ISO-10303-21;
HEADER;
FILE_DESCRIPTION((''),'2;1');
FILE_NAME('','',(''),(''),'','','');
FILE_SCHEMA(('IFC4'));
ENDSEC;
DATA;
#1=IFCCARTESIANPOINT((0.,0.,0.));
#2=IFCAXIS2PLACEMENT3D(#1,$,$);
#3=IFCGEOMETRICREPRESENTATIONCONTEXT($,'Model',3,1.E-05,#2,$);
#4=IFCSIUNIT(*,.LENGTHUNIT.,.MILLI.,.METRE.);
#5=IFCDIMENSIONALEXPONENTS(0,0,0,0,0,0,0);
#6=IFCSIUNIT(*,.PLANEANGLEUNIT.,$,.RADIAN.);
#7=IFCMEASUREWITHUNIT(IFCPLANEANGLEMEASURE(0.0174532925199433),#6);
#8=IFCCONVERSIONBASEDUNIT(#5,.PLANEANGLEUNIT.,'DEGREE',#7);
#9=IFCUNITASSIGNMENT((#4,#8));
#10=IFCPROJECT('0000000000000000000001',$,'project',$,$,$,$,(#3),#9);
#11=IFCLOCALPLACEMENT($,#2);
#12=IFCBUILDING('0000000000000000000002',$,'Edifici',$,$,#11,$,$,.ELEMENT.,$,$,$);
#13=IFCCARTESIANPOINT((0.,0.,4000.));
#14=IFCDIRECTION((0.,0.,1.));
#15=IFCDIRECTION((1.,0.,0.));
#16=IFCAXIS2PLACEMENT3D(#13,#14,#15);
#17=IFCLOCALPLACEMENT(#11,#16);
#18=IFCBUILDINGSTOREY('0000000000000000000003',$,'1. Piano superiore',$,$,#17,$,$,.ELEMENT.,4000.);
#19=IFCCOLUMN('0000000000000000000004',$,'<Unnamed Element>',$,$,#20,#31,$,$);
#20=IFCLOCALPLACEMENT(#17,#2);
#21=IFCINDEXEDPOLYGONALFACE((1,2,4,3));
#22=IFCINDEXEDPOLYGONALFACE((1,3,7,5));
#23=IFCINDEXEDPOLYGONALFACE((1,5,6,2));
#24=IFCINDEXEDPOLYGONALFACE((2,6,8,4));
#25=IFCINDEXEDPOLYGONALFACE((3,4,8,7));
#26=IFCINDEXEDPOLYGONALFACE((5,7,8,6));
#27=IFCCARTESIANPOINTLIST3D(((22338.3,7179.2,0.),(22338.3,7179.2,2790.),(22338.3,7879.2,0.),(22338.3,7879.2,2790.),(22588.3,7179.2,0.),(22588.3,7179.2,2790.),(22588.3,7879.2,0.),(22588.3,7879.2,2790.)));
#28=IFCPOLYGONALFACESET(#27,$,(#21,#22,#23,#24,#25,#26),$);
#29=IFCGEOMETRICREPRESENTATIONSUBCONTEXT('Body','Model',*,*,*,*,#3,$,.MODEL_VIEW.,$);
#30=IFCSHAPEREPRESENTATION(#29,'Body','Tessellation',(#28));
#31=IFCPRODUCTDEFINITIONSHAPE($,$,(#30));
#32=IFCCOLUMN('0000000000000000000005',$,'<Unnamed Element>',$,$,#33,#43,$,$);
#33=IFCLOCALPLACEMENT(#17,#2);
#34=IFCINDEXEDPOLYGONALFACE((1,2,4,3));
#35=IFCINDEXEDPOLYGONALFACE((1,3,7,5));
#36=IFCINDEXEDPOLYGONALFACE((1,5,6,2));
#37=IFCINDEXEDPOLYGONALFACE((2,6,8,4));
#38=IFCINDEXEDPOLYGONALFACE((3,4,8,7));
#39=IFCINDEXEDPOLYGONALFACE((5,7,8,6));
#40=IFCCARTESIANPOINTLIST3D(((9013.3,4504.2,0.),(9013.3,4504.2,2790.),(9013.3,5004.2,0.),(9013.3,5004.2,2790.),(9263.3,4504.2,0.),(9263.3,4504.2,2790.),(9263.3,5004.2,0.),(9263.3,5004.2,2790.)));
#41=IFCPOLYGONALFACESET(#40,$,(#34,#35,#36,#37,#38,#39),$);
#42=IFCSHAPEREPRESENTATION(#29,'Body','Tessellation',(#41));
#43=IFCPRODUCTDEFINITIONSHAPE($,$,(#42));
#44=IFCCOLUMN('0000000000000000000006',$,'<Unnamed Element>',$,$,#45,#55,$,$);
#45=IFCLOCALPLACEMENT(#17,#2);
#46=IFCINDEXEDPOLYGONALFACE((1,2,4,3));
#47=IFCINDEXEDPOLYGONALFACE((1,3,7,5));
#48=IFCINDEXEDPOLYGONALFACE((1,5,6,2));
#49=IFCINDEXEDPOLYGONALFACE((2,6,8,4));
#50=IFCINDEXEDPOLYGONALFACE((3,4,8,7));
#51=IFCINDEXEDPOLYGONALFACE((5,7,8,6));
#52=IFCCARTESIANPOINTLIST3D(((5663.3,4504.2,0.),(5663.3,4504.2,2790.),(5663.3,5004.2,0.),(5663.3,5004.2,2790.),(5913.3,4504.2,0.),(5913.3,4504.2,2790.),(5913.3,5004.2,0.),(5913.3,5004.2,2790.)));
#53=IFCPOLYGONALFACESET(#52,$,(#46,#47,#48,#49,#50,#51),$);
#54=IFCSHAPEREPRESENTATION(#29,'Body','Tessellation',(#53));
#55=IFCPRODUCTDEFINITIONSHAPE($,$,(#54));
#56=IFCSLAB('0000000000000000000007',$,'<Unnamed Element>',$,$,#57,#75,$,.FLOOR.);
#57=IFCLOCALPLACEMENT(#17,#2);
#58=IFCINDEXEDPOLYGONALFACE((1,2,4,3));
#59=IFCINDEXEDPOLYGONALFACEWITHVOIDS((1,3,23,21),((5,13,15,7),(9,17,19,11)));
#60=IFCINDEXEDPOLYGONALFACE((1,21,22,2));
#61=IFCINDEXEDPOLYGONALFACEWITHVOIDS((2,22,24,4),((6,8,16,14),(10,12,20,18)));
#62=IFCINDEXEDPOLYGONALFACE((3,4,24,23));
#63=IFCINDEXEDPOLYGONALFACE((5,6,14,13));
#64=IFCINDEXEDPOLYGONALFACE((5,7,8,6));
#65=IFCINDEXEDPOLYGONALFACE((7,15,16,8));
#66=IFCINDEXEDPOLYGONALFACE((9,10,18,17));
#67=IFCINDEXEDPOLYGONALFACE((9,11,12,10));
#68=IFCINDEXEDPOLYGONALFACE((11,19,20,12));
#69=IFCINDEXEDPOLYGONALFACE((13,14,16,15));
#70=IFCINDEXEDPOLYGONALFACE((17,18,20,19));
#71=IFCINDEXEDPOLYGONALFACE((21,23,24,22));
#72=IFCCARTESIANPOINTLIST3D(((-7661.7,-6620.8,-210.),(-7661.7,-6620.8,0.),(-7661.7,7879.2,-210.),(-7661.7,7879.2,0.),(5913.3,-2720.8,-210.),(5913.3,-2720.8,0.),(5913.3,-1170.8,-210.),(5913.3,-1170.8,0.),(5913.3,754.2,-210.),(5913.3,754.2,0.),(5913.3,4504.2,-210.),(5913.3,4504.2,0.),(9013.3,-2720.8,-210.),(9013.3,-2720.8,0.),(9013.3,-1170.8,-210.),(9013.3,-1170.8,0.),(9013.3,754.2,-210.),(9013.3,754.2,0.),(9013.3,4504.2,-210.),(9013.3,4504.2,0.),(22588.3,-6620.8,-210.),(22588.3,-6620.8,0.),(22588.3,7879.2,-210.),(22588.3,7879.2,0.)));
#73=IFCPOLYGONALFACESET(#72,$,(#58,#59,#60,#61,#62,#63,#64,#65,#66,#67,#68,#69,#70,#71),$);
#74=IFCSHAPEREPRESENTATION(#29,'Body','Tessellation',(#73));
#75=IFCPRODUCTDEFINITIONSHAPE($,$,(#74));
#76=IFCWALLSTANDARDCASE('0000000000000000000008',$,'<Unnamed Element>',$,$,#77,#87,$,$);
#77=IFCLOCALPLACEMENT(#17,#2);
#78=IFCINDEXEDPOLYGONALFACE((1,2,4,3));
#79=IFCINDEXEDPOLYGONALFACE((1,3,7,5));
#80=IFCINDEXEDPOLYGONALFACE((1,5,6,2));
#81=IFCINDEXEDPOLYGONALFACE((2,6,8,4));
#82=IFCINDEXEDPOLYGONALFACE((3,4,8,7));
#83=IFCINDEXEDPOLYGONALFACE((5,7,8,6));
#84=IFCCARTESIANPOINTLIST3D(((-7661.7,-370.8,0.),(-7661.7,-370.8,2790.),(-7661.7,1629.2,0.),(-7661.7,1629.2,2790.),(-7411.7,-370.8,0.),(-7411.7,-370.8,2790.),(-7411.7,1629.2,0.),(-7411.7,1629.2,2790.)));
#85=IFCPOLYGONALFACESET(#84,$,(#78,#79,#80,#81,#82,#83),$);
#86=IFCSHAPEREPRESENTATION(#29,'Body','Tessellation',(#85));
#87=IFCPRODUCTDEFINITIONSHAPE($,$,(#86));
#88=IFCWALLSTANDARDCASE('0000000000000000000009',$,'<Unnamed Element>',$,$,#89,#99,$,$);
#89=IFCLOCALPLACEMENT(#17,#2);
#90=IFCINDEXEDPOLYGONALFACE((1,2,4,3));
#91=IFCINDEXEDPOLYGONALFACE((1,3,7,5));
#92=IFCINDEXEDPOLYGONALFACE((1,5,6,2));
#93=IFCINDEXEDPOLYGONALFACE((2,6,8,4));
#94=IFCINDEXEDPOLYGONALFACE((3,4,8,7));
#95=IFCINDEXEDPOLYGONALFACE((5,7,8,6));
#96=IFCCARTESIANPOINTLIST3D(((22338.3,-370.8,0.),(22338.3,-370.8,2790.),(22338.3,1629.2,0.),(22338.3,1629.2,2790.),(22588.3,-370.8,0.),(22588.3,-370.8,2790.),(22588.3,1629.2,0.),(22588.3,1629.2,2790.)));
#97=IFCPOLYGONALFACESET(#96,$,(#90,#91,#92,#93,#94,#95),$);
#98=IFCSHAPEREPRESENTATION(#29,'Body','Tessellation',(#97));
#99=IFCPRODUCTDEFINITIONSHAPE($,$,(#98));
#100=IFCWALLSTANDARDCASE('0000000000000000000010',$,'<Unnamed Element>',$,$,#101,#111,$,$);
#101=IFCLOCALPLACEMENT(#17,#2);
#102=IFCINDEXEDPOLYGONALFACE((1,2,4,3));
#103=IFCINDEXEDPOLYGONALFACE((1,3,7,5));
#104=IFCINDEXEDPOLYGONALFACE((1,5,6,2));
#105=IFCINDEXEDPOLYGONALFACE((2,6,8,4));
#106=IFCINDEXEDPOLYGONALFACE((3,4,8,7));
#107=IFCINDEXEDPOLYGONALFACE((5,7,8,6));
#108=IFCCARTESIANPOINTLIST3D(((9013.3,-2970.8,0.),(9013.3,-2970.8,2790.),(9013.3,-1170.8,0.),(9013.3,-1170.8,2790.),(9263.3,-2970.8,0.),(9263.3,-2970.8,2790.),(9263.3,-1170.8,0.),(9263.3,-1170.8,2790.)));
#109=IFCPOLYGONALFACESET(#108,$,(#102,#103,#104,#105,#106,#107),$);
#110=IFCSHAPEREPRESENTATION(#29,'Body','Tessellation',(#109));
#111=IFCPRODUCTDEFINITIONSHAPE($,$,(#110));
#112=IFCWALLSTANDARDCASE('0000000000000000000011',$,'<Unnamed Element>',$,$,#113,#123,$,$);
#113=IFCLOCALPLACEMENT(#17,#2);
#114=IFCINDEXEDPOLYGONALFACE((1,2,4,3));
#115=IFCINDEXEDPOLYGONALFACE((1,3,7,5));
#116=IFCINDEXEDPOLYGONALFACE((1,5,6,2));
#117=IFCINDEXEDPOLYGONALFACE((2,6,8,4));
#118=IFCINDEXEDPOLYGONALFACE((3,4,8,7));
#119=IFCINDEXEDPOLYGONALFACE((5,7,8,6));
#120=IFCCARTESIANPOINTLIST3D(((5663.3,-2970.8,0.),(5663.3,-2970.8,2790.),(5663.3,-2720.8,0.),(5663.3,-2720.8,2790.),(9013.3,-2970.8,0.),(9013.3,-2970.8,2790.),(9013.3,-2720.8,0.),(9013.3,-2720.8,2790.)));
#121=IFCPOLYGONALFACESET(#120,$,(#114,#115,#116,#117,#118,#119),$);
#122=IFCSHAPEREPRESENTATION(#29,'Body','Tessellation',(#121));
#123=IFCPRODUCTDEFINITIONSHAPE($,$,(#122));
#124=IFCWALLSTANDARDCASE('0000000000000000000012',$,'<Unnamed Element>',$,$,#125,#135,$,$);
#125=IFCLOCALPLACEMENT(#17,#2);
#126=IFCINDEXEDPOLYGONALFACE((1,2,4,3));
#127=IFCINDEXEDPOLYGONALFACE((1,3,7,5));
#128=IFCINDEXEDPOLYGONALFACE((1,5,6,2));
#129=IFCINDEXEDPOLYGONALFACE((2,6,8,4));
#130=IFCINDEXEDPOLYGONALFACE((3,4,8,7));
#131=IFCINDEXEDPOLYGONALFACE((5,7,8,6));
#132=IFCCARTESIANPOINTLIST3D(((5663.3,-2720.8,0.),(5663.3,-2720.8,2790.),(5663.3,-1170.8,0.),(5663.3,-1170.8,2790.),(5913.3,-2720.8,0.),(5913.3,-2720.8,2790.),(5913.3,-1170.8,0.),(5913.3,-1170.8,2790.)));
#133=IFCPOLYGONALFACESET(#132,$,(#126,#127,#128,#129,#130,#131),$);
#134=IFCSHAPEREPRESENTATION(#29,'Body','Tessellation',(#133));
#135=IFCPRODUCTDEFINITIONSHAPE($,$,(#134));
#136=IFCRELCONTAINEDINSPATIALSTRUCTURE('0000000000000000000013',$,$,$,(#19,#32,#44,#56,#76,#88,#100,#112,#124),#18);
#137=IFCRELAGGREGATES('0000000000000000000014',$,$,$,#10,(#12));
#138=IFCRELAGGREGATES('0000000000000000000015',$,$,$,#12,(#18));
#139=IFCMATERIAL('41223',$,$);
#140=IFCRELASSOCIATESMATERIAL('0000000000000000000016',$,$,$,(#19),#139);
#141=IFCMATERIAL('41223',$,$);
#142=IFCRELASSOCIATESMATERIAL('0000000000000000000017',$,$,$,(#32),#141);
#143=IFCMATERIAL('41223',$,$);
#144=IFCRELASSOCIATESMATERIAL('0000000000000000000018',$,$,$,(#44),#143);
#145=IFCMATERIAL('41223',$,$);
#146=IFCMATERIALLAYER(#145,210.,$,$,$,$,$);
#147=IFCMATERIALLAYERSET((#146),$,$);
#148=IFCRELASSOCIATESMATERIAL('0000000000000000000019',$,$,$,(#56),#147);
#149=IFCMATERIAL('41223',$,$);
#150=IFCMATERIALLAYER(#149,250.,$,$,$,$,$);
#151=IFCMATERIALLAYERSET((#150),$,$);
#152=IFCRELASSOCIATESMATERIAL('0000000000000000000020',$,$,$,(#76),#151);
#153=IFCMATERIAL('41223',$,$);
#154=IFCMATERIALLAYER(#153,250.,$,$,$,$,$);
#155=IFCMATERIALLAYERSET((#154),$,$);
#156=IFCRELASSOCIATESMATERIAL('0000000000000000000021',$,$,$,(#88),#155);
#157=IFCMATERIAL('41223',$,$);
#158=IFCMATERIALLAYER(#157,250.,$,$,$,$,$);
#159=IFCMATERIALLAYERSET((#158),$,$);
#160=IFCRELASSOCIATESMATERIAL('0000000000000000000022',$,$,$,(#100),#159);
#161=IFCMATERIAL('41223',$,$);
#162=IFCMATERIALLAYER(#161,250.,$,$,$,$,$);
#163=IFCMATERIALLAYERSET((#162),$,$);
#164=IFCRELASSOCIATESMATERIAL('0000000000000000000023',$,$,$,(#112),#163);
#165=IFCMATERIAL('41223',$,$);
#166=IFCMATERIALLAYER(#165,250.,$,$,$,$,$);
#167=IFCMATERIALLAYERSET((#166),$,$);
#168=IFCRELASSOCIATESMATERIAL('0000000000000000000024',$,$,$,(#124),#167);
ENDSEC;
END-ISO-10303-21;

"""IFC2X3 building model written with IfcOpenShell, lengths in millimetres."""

from ifc_helpers import new_model, entity, si_unit, converted_unit, frame, frame_2d, origin, origin_with_axes, place, context, subcontext, project, spatial, polyline, rectangle, outline, extrude, material, layer, layer_set, layer_usage, element, save


model = new_model("IFC2X3")

# Units and contexts
model_context = context("Model", 3, precision=1e-05, world=origin())
body_context = subcontext(model_context, "Body", "Model", "MODEL_VIEW")
ifc_project = project(units=[si_unit("LENGTHUNIT", "METRE", prefix="MILLI"), converted_unit("PLANEANGLEUNIT", "DEGREE", entity("IfcPlaneAngleMeasure", 0.0174532925199433), si_unit("PLANEANGLEUNIT", "RADIAN"), dimensions=[0, 0, 0, 0, 0, 0, 0])], contexts=[model_context])

# Building, storey
building_placement = place(None, origin())
building = spatial("IfcBuilding", under=ifc_project, at=building_placement, Name="Edifici", CompositionType="ELEMENT")
storey_placement = place(building_placement, frame((0.0, 0.0, 4000.0), z_axis=(0.0, 0.0, 1.0), x_axis=(1.0, 0.0, 0.0)))
storey = spatial("IfcBuildingStorey", under=building, at=storey_placement, Name="1. Piano superiore", CompositionType="ELEMENT", Elevation=4000.0)

# Columns
ifc_material_1 = material(Name="41223")
column_1_placement = place(storey_placement, frame((22588.3, 7879.2, 0.0), z_axis=(0.0, 0.0, 1.0), x_axis=(1.0, 0.0, 0.0)))
element("IfcColumn", 1, at=column_1_placement, inside=storey, material=ifc_material_1, Name="<Unnamed Element>", context=body_context, shape_type="SweptSolid", body=[
    extrude(rectangle(XDim=250.0, YDim=700.0, at=frame_2d((-125.0, -350.0), x_axis=(-1.0, 0.0))), origin_with_axes(), (0.0, 0.0, 1.0), 2790.0),
])
ifc_material_2 = material(Name="41223")
column_2_placement = place(storey_placement, frame((9263.3, 5004.2, 0.0), z_axis=(0.0, 0.0, 1.0), x_axis=(1.0, 0.0, 0.0)))
element("IfcColumn", 2, at=column_2_placement, inside=storey, material=ifc_material_2, Name="<Unnamed Element>", context=body_context, shape_type="SweptSolid", body=[
    extrude(rectangle(XDim=250.0, YDim=500.0, at=frame_2d((-125.0, -250.0), x_axis=(-1.0, 0.0))), origin_with_axes(), (0.0, 0.0, 1.0), 2790.0),
])
ifc_material_3 = material(Name="41223")
column_3_placement = place(storey_placement, frame((5913.3, 5004.2, 0.0), z_axis=(0.0, 0.0, 1.0), x_axis=(1.0, 0.0, 0.0)))
element("IfcColumn", 3, at=column_3_placement, inside=storey, material=ifc_material_3, Name="<Unnamed Element>", context=body_context, shape_type="SweptSolid", body=[
    extrude(rectangle(XDim=250.0, YDim=500.0, at=frame_2d((-125.0, -250.0), x_axis=(-1.0, 0.0))), origin_with_axes(), (0.0, 0.0, 1.0), 2790.0),
])

# Slab
ifc_material_4 = material(Name="41223")
ifc_layer_1 = layer(ifc_material_4, 210.0)
ifc_layer_set_1 = layer_set([ifc_layer_1])
ifc_layer_usage_1 = layer_usage(ifc_layer_set_1, "AXIS3", "POSITIVE", 0.0)
slab_placement = place(storey_placement, frame((-7661.7, -6620.8, -210.0), z_axis=(0.0, 0.0, 1.0), x_axis=(1.0, 0.0, 0.0)))
element("IfcSlab", 4, at=slab_placement, inside=storey, material=ifc_layer_usage_1, Name="<Unnamed Element>", PredefinedType="FLOOR", context=body_context, shape_type="SweptSolid", body=[
    extrude(outline(polyline([(0.0, 0.0), (30250.0, 0.0), (30250.0, 14500.0), (0.0, 14500.0), (0.0, 0.0)]), holes=[polyline([(13575.0, 11125.0), (16675.0, 11125.0), (16675.0, 7375.0), (13575.0, 7375.0), (13575.0, 11125.0)]), polyline([(16675.0, 3900.0), (13575.0, 3900.0), (13575.0, 5450.0), (16675.0, 5450.0), (16675.0, 3900.0)])]), origin_with_axes(), (0.0, 0.0, 1.0), 210.0),
])

# Walls
ifc_material_5 = material(Name="41223")
ifc_layer_2 = layer(ifc_material_5, 250.0)
ifc_layer_set_2 = layer_set([ifc_layer_2])
ifc_layer_usage_2 = layer_usage(ifc_layer_set_2, "AXIS2", "POSITIVE", 0.0)
wall_1_placement = place(storey_placement, frame((-7661.7, 1629.2, 0.0), z_axis=(0.0, 0.0, 1.0), x_axis=(0.0, -1.0, 0.0)))
element("IfcWallStandardCase", 5, at=wall_1_placement, inside=storey, material=ifc_layer_usage_2, Name="<Unnamed Element>", context=body_context, shape_type="SweptSolid", body=[
    extrude(rectangle(XDim=2000.0, YDim=250.0, at=frame_2d((1000.0, 125.0), x_axis=(1.0, 0.0))), origin_with_axes(), (0.0, 0.0, 1.0), 2790.0),
])
ifc_material_6 = material(Name="41223")
ifc_layer_3 = layer(ifc_material_6, 250.0)
ifc_layer_set_3 = layer_set([ifc_layer_3])
ifc_layer_usage_3 = layer_usage(ifc_layer_set_3, "AXIS2", "POSITIVE", 0.0)
wall_2_placement = place(storey_placement, frame((22338.3, 1629.2, 0.0), z_axis=(0.0, 0.0, 1.0), x_axis=(0.0, -1.0, 0.0)))
element("IfcWallStandardCase", 6, at=wall_2_placement, inside=storey, material=ifc_layer_usage_3, Name="<Unnamed Element>", context=body_context, shape_type="SweptSolid", body=[
    extrude(rectangle(XDim=2000.0, YDim=250.0, at=frame_2d((1000.0, 125.0), x_axis=(1.0, 0.0))), origin_with_axes(), (0.0, 0.0, 1.0), 2790.0),
])
ifc_material_7 = material(Name="41223")
ifc_layer_4 = layer(ifc_material_7, 250.0)
ifc_layer_set_4 = layer_set([ifc_layer_4])
ifc_layer_usage_4 = layer_usage(ifc_layer_set_4, "AXIS2", "POSITIVE", 0.0)
wall_3_placement = place(storey_placement, frame((9263.3, -2970.8, 0.0), z_axis=(0.0, 0.0, 1.0), x_axis=(0.0, 1.0, 0.0)))
element("IfcWallStandardCase", 7, at=wall_3_placement, inside=storey, material=ifc_layer_usage_4, Name="<Unnamed Element>", context=body_context, shape_type="SweptSolid", body=[
    extrude(rectangle(XDim=1800.0, YDim=250.0, at=frame_2d((900.0, 125.0), x_axis=(1.0, 0.0))), origin_with_axes(), (0.0, 0.0, 1.0), 2790.0),
])
ifc_material_8 = material(Name="41223")
ifc_layer_5 = layer(ifc_material_8, 250.0)
ifc_layer_set_5 = layer_set([ifc_layer_5])
ifc_layer_usage_5 = layer_usage(ifc_layer_set_5, "AXIS2", "POSITIVE", 0.0)
wall_4_placement = place(storey_placement, frame((5663.3, -2970.8, 0.0), z_axis=(0.0, 0.0, 1.0), x_axis=(1.0, 0.0, 0.0)))
element("IfcWallStandardCase", 8, at=wall_4_placement, inside=storey, material=ifc_layer_usage_5, Name="<Unnamed Element>", context=body_context, shape_type="SweptSolid", body=[
    extrude(rectangle(XDim=3350.0, YDim=250.0, at=frame_2d((1675.0, 125.0), x_axis=(1.0, 0.0))), origin_with_axes(), (0.0, 0.0, 1.0), 2790.0),
])
ifc_material_9 = material(Name="41223")
ifc_layer_6 = layer(ifc_material_9, 250.0)
ifc_layer_set_6 = layer_set([ifc_layer_6])
ifc_layer_usage_6 = layer_usage(ifc_layer_set_6, "AXIS2", "POSITIVE", 0.0)
wall_5_placement = place(storey_placement, frame((5663.3, -1170.8, 0.0), z_axis=(0.0, 0.0, 1.0), x_axis=(0.0, -1.0, 0.0)))
element("IfcWallStandardCase", 9, at=wall_5_placement, inside=storey, material=ifc_layer_usage_6, Name="<Unnamed Element>", context=body_context, shape_type="SweptSolid", body=[
    extrude(rectangle(XDim=1550.0, YDim=250.0, at=frame_2d((775.0, 125.0), x_axis=(1.0, 0.0))), origin_with_axes(), (0.0, 0.0, 1.0), 2790.0),
])

save(model, "model.ifc")
